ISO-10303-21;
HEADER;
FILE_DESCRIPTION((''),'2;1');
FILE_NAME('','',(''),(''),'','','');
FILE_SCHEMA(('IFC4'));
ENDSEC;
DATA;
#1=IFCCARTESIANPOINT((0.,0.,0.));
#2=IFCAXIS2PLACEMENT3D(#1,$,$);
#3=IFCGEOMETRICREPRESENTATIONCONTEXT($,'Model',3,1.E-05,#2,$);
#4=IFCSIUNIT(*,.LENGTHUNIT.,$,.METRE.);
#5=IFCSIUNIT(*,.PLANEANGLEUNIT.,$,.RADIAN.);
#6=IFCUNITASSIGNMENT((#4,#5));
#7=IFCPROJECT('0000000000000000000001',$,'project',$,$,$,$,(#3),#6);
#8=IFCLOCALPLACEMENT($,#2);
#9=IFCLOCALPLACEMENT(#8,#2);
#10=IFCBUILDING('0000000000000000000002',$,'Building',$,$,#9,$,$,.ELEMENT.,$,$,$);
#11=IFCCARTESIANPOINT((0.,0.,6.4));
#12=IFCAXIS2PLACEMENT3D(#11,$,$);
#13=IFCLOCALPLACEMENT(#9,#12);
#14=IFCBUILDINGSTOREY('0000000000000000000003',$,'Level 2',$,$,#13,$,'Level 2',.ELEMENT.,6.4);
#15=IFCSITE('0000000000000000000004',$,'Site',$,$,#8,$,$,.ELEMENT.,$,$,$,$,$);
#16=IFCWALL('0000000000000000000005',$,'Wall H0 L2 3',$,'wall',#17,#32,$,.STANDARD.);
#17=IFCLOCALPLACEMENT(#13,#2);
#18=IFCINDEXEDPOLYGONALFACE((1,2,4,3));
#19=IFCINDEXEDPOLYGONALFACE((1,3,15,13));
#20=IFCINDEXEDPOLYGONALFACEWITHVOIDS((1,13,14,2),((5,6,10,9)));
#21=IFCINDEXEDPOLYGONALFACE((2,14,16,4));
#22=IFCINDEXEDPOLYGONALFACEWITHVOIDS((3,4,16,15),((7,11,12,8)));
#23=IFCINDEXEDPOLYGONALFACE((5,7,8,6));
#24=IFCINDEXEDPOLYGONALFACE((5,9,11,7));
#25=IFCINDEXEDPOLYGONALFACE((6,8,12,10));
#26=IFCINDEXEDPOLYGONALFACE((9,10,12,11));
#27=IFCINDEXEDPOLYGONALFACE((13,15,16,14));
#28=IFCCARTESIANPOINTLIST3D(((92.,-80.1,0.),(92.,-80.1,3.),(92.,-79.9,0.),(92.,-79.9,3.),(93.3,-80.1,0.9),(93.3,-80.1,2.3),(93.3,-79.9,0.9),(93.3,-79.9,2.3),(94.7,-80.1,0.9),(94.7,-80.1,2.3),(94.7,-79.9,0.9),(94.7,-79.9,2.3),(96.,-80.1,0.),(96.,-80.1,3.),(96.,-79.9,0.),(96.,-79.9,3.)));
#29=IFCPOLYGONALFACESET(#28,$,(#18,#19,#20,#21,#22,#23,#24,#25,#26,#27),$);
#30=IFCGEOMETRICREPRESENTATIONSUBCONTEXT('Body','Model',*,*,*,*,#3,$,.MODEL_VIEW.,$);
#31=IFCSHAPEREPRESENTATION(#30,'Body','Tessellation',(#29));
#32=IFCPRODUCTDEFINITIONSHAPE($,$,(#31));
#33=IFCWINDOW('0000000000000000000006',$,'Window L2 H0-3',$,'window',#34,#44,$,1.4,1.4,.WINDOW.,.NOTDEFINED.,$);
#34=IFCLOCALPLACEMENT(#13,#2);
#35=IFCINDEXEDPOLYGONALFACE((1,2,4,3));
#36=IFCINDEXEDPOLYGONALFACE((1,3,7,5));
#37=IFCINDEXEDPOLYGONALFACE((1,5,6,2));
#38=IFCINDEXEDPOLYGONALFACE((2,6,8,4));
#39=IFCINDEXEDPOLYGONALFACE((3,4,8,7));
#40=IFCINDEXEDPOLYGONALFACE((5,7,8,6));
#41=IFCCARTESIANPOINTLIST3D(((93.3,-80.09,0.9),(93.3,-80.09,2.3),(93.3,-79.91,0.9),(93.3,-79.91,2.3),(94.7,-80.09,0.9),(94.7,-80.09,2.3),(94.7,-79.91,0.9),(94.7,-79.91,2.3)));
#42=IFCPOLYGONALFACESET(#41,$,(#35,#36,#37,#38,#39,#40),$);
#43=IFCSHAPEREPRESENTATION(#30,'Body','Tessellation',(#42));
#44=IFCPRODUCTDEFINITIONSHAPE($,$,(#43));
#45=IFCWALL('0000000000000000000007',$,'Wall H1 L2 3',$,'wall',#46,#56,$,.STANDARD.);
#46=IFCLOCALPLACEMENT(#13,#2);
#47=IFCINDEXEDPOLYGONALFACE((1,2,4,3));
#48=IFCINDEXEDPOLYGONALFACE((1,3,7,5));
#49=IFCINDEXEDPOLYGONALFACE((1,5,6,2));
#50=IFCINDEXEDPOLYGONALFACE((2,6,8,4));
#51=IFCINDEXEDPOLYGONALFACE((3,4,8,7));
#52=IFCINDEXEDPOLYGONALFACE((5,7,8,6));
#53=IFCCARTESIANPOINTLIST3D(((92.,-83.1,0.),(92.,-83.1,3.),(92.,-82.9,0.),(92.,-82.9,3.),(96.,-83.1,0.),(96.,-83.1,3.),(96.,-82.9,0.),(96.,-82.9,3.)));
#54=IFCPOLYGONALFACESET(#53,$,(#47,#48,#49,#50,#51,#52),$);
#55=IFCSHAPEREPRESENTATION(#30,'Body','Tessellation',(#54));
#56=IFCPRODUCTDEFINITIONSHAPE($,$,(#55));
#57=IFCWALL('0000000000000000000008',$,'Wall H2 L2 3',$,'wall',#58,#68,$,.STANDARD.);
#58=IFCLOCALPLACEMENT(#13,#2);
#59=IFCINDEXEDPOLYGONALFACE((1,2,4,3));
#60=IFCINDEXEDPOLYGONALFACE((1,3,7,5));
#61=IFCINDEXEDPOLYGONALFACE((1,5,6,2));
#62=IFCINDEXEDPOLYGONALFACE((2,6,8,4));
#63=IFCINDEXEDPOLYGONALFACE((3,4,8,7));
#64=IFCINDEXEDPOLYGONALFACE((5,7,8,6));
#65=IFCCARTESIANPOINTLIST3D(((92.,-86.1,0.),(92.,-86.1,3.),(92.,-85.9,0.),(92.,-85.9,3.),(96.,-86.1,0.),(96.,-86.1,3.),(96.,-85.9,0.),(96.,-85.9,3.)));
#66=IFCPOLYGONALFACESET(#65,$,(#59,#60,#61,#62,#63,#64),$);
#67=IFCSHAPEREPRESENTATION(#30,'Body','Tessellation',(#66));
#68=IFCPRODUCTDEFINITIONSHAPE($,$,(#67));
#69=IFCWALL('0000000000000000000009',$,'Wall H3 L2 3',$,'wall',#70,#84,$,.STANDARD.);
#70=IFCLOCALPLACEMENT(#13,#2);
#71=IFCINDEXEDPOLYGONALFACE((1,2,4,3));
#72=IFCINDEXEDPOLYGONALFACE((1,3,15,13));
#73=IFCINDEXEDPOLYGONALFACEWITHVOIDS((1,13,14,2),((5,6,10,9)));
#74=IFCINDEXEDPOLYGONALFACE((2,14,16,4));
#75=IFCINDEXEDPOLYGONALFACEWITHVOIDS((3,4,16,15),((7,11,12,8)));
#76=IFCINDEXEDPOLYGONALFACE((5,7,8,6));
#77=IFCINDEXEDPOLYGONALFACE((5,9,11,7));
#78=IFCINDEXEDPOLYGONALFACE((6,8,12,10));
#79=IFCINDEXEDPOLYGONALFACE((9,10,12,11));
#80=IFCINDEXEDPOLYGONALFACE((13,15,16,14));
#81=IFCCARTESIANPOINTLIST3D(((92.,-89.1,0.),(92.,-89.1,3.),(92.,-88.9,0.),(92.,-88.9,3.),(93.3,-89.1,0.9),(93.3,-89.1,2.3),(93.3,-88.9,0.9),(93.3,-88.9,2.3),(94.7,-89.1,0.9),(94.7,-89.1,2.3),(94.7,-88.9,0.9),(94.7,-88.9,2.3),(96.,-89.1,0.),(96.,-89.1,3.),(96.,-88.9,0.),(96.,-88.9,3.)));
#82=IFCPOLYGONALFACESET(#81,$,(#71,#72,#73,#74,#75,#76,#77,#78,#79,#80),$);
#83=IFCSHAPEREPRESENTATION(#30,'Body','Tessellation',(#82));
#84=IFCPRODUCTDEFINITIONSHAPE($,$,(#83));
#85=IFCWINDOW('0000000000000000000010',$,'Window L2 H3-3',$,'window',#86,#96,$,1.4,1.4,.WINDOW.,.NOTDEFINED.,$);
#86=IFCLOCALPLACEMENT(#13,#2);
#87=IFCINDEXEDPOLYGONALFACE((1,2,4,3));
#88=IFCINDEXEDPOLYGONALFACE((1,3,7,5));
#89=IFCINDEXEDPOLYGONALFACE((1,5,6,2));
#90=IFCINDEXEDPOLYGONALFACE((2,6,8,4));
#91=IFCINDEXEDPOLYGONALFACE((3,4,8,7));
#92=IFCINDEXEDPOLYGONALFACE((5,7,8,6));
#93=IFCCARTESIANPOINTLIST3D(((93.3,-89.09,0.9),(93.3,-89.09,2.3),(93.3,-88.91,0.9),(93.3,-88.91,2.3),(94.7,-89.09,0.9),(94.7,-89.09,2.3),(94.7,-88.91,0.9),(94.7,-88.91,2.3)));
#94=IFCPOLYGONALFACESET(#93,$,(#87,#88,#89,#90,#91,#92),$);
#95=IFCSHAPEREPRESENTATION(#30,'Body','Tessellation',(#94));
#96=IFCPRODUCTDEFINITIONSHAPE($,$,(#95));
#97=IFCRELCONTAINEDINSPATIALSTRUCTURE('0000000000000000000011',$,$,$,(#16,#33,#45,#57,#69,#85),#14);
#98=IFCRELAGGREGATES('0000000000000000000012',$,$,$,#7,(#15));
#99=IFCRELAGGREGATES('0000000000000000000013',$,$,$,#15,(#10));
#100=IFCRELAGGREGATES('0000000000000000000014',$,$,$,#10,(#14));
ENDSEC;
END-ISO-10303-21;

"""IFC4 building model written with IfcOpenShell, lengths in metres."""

from ifc_helpers import new_model, si_unit, frame, frame_2d, origin, origin_2d, place, context, subcontext, project, spatial, rectangle, extrude, element, fill, save


model = new_model("IFC4")

# Units and contexts
model_context = context("Model", 3, precision=1e-05, world=origin())
body_context = subcontext(model_context, "Body", "Model", "MODEL_VIEW")
ifc_project = project(units=[si_unit("LENGTHUNIT", "METRE"), si_unit("PLANEANGLEUNIT", "RADIAN")], contexts=[model_context])

# Site, building, storey
site_placement = place(None, origin())
site = spatial("IfcSite", under=ifc_project, at=site_placement, Name="Site", CompositionType="ELEMENT")
building_placement = place(site_placement, origin())
building = spatial("IfcBuilding", under=site, at=building_placement, Name="Building", CompositionType="ELEMENT")
storey_placement = place(building_placement, frame((0.0, 0.0, 6.4)))
storey = spatial("IfcBuildingStorey", under=building, at=storey_placement, Name="Level 2", LongName="Level 2", CompositionType="ELEMENT", Elevation=6.4)

# Wall, opening, window
wall_1_placement = place(storey_placement, frame((92.0, -80.0, 0.0), z_axis=(0.0, 0.0, 1.0), x_axis=(1.0, 0.0, 0.0)))
wall_1 = element("IfcWall", 1, at=wall_1_placement, inside=storey, Name="Wall H0 L2 3", ObjectType="wall", PredefinedType="STANDARD", context=body_context, shape_type="SweptSolid", body=[
    extrude(rectangle(XDim=4.0, YDim=0.2, at=frame_2d((2.0, 0.0))), origin(), (0.0, 0.0, 1.0), 3.0),
])
opening_1_placement = place(storey_placement, frame((94.0, -80.0, 0.9), z_axis=(0.0, 0.0, 1.0), x_axis=(1.0, 0.0, 0.0)))
opening_1 = element("IfcOpeningElement", 2, at=opening_1_placement, cuts=wall_1, ObjectType="Opening", PredefinedType="OPENING", context=body_context, shape_type="SweptSolid", body=[
    extrude(rectangle(XDim=1.4, YDim=0.22, at=origin_2d()), origin(), (0.0, 0.0, 1.0), 1.4),
])
window_1_placement = place(storey_placement, frame((94.0, -80.0, 0.9), z_axis=(0.0, 0.0, 1.0), x_axis=(1.0, 0.0, 0.0)))
window_1 = element("IfcWindow", 3, at=window_1_placement, inside=storey, Name="Window L2 H0-3", ObjectType="window", OverallHeight=1.4, OverallWidth=1.4, PartitioningType="NOTDEFINED", PredefinedType="WINDOW", context=body_context, shape_type="SweptSolid", body=[
    extrude(rectangle(XDim=1.4, YDim=0.18, at=origin_2d()), origin(), (0.0, 0.0, 1.0), 1.4),
])
fill(opening_1, window_1)

# Walls
for number, where, z_axis, x_axis, name in (
    (4, (92.0, -83.0, 0.0), (0.0, 0.0, 1.0), (1.0, 0.0, 0.0), "Wall H1 L2 3"),
    (5, (92.0, -86.0, 0.0), (0.0, 0.0, 1.0), (1.0, 0.0, 0.0), "Wall H2 L2 3"),
):
    element("IfcWall", number, at=place(storey_placement, frame(where, z_axis=z_axis, x_axis=x_axis)), inside=storey, Name=name, ObjectType="wall", PredefinedType="STANDARD", context=body_context, shape_type="SweptSolid", body=[
        extrude(rectangle(XDim=4.0, YDim=0.2, at=frame_2d((2.0, 0.0))), origin(), (0.0, 0.0, 1.0), 3.0),
    ])

# Wall, opening, window
wall_2_placement = place(storey_placement, frame((92.0, -89.0, 0.0), z_axis=(0.0, 0.0, 1.0), x_axis=(1.0, 0.0, 0.0)))
wall_2 = element("IfcWall", 6, at=wall_2_placement, inside=storey, Name="Wall H3 L2 3", ObjectType="wall", PredefinedType="STANDARD", context=body_context, shape_type="SweptSolid", body=[
    extrude(rectangle(XDim=4.0, YDim=0.2, at=frame_2d((2.0, 0.0))), origin(), (0.0, 0.0, 1.0), 3.0),
])
opening_2_placement = place(storey_placement, frame((94.0, -89.0, 0.9), z_axis=(0.0, 0.0, 1.0), x_axis=(1.0, 0.0, 0.0)))
opening_2 = element("IfcOpeningElement", 7, at=opening_2_placement, cuts=wall_2, ObjectType="Opening", PredefinedType="OPENING", context=body_context, shape_type="SweptSolid", body=[
    extrude(rectangle(XDim=1.4, YDim=0.22, at=origin_2d()), origin(), (0.0, 0.0, 1.0), 1.4),
])
window_2_placement = place(storey_placement, frame((94.0, -89.0, 0.9), z_axis=(0.0, 0.0, 1.0), x_axis=(1.0, 0.0, 0.0)))
window_2 = element("IfcWindow", 8, at=window_2_placement, inside=storey, Name="Window L2 H3-3", ObjectType="window", OverallHeight=1.4, OverallWidth=1.4, PartitioningType="NOTDEFINED", PredefinedType="WINDOW", context=body_context, shape_type="SweptSolid", body=[
    extrude(rectangle(XDim=1.4, YDim=0.18, at=origin_2d()), origin(), (0.0, 0.0, 1.0), 1.4),
])
fill(opening_2, window_2)

save(model, "model.ifc")
